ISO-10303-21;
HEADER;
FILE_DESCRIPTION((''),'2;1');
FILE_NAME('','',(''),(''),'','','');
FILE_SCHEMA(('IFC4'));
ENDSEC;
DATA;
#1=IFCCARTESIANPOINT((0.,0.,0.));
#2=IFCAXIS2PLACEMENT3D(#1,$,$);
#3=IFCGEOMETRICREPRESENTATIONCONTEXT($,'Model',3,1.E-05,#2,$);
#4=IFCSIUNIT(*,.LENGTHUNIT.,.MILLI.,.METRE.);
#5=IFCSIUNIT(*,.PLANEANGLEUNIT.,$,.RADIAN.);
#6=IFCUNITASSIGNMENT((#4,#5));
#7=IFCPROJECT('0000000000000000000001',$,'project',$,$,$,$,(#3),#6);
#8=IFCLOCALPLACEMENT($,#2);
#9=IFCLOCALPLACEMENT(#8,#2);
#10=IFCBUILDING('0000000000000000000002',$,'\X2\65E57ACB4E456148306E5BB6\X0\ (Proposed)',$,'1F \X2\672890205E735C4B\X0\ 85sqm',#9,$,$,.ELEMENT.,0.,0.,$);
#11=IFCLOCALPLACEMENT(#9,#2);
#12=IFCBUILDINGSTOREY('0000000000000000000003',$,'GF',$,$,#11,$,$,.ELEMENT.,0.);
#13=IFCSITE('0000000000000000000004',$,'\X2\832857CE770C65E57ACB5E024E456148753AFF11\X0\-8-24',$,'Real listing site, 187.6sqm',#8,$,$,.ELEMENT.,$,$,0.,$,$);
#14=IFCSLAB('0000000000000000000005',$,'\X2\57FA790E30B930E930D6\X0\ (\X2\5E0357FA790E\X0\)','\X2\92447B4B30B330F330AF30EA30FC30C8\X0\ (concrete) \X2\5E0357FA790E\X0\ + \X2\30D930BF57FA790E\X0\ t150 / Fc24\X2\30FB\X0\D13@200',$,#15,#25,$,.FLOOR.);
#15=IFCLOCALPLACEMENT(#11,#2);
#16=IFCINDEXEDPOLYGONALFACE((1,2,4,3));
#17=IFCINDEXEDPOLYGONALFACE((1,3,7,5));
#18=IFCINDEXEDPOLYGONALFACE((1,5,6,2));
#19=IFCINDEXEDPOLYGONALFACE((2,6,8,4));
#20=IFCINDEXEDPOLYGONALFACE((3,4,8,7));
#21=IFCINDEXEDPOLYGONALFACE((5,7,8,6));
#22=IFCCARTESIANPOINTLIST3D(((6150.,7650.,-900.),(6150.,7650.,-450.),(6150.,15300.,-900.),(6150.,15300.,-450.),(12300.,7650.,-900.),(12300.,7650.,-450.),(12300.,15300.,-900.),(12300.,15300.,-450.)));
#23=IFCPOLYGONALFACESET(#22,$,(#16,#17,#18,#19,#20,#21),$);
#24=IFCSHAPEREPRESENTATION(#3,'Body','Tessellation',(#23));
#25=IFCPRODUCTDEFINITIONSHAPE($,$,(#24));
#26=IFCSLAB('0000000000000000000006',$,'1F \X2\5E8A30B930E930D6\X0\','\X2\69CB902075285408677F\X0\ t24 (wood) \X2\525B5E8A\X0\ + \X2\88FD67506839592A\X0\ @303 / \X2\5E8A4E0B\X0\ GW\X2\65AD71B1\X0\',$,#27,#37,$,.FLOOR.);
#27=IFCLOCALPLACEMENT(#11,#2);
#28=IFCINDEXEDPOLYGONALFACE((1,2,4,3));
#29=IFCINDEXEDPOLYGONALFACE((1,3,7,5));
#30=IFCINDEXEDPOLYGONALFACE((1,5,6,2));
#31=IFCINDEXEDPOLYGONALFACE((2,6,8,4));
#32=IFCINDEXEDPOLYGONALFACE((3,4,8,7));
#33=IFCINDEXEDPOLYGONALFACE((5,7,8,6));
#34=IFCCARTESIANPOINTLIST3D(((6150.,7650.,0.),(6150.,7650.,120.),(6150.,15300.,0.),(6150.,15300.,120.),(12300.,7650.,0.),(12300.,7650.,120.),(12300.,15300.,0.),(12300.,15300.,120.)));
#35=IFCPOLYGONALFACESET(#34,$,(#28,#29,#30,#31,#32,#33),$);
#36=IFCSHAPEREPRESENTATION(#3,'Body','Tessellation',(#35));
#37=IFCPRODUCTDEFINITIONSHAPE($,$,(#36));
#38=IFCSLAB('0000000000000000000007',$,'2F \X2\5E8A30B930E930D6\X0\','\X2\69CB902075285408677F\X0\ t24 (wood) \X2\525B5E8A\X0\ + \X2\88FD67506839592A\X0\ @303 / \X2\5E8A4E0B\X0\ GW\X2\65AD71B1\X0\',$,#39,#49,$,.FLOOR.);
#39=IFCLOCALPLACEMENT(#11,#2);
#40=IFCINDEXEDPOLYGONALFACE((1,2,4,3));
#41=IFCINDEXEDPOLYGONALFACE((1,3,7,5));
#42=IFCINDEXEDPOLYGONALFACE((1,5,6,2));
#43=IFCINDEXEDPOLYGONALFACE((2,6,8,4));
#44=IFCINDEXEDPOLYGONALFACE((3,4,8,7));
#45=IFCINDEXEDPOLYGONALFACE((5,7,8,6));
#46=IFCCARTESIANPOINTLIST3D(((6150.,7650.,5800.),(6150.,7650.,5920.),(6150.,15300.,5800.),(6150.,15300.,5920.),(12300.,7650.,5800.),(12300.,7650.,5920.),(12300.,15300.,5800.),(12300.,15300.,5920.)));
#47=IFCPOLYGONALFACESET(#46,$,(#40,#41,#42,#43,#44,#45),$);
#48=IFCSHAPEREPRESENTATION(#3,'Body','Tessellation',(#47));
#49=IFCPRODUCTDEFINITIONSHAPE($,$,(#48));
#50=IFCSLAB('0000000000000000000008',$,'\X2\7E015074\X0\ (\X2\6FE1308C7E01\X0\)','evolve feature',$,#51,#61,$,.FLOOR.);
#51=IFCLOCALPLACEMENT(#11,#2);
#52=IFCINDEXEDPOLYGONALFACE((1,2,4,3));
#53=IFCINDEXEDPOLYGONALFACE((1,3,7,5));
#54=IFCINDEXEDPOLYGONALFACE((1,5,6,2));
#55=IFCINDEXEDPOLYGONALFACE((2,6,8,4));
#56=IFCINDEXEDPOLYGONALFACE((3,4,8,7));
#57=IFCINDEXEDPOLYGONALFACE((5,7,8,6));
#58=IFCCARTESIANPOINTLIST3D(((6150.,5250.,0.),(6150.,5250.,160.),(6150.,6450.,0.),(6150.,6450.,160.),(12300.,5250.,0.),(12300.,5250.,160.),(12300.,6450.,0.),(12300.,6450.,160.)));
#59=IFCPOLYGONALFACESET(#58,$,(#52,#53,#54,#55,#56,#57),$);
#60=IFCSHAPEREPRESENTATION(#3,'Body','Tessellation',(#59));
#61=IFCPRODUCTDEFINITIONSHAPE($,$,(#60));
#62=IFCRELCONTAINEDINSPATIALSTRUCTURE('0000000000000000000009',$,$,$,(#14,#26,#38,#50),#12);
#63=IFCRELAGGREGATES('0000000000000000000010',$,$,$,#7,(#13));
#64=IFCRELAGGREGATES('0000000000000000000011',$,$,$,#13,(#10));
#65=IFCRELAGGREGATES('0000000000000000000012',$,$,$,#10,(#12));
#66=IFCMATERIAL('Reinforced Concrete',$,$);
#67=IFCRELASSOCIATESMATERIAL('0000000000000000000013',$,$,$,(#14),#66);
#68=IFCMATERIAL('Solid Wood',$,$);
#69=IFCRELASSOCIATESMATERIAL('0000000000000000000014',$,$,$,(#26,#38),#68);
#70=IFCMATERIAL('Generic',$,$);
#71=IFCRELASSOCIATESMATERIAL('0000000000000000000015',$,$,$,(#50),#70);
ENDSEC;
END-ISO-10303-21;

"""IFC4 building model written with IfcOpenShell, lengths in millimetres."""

from ifc_helpers import new_model, si_unit, frame, frame_2d, origin, place, context, project, spatial, rectangle, extrude, material, element, save


model = new_model("IFC4")

# Units and contexts
model_context = context("Model", 3, precision=1e-05, world=origin())
ifc_project = project(units=[si_unit("LENGTHUNIT", "METRE", prefix="MILLI"), si_unit("PLANEANGLEUNIT", "RADIAN")], contexts=[model_context])

# Site, building, storey
site_placement = place(None, origin())
site = spatial("IfcSite", under=ifc_project, at=site_placement, Name="茨城県日立市久慈町１-8-24", ObjectType="Real listing site, 187.6sqm", CompositionType="ELEMENT", RefElevation=0.0)
building_placement = place(site_placement, origin())
building = spatial("IfcBuilding", under=site, at=building_placement, Name="日立久慈の家 (Proposed)", ObjectType="1F 木造平屋 85sqm", CompositionType="ELEMENT", ElevationOfRefHeight=0.0, ElevationOfTerrain=0.0)
storey_placement = place(building_placement, origin())
storey = spatial("IfcBuildingStorey", under=building, at=storey_placement, Name="GF", CompositionType="ELEMENT", Elevation=0.0)

# Slabs
ifc_material_1 = material(Name="Reinforced Concrete")
slab_1_placement = place(storey_placement, frame((3075.0, 3825.0, -450.0)))
element("IfcSlab", 1, at=slab_1_placement, inside=storey, material=ifc_material_1, Name="基礎スラブ (布基礎)", Description="鉄筋コンクリート (concrete) 布基礎 + ベタ基礎 t150 / Fc24・D13@200", PredefinedType="FLOOR", context=model_context, shape_type="SweptSolid", body=[
    extrude(rectangle(XDim=6150.0, YDim=7650.0, at=frame_2d((3075.0, 3825.0))), frame((3075.0, 3825.0, -450.0)), (0.0, 0.0, 1.0), 450.0),
])
ifc_material_2 = material(Name="Solid Wood")
slab_2_placement = place(storey_placement, frame((3075.0, 3825.0, 0.0)))
element("IfcSlab", 2, at=slab_2_placement, inside=storey, material=ifc_material_2, Name="1F 床スラブ", Description="構造用合板 t24 (wood) 剛床 + 製材根太 @303 / 床下 GW断熱", PredefinedType="FLOOR", context=model_context, shape_type="SweptSolid", body=[
    extrude(rectangle(XDim=6150.0, YDim=7650.0, at=frame_2d((3075.0, 3825.0))), frame((3075.0, 3825.0, 0.0)), (0.0, 0.0, 1.0), 120.0),
])
slab_3_placement = place(storey_placement, frame((3075.0, 3825.0, 2900.0)))
element("IfcSlab", 3, at=slab_3_placement, inside=storey, material=ifc_material_2, Name="2F 床スラブ", Description="構造用合板 t24 (wood) 剛床 + 製材根太 @303 / 床下 GW断熱", PredefinedType="FLOOR", context=model_context, shape_type="SweptSolid", body=[
    extrude(rectangle(XDim=6150.0, YDim=7650.0, at=frame_2d((3075.0, 3825.0))), frame((3075.0, 3825.0, 2900.0)), (0.0, 0.0, 1.0), 120.0),
])
ifc_material_3 = material(Name="Generic")
slab_4_placement = place(storey_placement, frame((3075.0, 2625.0, 0.0)))
element("IfcSlab", 4, at=slab_4_placement, inside=storey, material=ifc_material_3, Name="縁側 (濡れ縁)", Description="evolve feature", PredefinedType="FLOOR", context=model_context, shape_type="SweptSolid", body=[
    extrude(rectangle(XDim=6150.0, YDim=1200.0, at=frame_2d((3075.0, 600.0))), frame((3075.0, 2625.0, 0.0)), (0.0, 0.0, 1.0), 160.0),
])

save(model, "model.ifc")
